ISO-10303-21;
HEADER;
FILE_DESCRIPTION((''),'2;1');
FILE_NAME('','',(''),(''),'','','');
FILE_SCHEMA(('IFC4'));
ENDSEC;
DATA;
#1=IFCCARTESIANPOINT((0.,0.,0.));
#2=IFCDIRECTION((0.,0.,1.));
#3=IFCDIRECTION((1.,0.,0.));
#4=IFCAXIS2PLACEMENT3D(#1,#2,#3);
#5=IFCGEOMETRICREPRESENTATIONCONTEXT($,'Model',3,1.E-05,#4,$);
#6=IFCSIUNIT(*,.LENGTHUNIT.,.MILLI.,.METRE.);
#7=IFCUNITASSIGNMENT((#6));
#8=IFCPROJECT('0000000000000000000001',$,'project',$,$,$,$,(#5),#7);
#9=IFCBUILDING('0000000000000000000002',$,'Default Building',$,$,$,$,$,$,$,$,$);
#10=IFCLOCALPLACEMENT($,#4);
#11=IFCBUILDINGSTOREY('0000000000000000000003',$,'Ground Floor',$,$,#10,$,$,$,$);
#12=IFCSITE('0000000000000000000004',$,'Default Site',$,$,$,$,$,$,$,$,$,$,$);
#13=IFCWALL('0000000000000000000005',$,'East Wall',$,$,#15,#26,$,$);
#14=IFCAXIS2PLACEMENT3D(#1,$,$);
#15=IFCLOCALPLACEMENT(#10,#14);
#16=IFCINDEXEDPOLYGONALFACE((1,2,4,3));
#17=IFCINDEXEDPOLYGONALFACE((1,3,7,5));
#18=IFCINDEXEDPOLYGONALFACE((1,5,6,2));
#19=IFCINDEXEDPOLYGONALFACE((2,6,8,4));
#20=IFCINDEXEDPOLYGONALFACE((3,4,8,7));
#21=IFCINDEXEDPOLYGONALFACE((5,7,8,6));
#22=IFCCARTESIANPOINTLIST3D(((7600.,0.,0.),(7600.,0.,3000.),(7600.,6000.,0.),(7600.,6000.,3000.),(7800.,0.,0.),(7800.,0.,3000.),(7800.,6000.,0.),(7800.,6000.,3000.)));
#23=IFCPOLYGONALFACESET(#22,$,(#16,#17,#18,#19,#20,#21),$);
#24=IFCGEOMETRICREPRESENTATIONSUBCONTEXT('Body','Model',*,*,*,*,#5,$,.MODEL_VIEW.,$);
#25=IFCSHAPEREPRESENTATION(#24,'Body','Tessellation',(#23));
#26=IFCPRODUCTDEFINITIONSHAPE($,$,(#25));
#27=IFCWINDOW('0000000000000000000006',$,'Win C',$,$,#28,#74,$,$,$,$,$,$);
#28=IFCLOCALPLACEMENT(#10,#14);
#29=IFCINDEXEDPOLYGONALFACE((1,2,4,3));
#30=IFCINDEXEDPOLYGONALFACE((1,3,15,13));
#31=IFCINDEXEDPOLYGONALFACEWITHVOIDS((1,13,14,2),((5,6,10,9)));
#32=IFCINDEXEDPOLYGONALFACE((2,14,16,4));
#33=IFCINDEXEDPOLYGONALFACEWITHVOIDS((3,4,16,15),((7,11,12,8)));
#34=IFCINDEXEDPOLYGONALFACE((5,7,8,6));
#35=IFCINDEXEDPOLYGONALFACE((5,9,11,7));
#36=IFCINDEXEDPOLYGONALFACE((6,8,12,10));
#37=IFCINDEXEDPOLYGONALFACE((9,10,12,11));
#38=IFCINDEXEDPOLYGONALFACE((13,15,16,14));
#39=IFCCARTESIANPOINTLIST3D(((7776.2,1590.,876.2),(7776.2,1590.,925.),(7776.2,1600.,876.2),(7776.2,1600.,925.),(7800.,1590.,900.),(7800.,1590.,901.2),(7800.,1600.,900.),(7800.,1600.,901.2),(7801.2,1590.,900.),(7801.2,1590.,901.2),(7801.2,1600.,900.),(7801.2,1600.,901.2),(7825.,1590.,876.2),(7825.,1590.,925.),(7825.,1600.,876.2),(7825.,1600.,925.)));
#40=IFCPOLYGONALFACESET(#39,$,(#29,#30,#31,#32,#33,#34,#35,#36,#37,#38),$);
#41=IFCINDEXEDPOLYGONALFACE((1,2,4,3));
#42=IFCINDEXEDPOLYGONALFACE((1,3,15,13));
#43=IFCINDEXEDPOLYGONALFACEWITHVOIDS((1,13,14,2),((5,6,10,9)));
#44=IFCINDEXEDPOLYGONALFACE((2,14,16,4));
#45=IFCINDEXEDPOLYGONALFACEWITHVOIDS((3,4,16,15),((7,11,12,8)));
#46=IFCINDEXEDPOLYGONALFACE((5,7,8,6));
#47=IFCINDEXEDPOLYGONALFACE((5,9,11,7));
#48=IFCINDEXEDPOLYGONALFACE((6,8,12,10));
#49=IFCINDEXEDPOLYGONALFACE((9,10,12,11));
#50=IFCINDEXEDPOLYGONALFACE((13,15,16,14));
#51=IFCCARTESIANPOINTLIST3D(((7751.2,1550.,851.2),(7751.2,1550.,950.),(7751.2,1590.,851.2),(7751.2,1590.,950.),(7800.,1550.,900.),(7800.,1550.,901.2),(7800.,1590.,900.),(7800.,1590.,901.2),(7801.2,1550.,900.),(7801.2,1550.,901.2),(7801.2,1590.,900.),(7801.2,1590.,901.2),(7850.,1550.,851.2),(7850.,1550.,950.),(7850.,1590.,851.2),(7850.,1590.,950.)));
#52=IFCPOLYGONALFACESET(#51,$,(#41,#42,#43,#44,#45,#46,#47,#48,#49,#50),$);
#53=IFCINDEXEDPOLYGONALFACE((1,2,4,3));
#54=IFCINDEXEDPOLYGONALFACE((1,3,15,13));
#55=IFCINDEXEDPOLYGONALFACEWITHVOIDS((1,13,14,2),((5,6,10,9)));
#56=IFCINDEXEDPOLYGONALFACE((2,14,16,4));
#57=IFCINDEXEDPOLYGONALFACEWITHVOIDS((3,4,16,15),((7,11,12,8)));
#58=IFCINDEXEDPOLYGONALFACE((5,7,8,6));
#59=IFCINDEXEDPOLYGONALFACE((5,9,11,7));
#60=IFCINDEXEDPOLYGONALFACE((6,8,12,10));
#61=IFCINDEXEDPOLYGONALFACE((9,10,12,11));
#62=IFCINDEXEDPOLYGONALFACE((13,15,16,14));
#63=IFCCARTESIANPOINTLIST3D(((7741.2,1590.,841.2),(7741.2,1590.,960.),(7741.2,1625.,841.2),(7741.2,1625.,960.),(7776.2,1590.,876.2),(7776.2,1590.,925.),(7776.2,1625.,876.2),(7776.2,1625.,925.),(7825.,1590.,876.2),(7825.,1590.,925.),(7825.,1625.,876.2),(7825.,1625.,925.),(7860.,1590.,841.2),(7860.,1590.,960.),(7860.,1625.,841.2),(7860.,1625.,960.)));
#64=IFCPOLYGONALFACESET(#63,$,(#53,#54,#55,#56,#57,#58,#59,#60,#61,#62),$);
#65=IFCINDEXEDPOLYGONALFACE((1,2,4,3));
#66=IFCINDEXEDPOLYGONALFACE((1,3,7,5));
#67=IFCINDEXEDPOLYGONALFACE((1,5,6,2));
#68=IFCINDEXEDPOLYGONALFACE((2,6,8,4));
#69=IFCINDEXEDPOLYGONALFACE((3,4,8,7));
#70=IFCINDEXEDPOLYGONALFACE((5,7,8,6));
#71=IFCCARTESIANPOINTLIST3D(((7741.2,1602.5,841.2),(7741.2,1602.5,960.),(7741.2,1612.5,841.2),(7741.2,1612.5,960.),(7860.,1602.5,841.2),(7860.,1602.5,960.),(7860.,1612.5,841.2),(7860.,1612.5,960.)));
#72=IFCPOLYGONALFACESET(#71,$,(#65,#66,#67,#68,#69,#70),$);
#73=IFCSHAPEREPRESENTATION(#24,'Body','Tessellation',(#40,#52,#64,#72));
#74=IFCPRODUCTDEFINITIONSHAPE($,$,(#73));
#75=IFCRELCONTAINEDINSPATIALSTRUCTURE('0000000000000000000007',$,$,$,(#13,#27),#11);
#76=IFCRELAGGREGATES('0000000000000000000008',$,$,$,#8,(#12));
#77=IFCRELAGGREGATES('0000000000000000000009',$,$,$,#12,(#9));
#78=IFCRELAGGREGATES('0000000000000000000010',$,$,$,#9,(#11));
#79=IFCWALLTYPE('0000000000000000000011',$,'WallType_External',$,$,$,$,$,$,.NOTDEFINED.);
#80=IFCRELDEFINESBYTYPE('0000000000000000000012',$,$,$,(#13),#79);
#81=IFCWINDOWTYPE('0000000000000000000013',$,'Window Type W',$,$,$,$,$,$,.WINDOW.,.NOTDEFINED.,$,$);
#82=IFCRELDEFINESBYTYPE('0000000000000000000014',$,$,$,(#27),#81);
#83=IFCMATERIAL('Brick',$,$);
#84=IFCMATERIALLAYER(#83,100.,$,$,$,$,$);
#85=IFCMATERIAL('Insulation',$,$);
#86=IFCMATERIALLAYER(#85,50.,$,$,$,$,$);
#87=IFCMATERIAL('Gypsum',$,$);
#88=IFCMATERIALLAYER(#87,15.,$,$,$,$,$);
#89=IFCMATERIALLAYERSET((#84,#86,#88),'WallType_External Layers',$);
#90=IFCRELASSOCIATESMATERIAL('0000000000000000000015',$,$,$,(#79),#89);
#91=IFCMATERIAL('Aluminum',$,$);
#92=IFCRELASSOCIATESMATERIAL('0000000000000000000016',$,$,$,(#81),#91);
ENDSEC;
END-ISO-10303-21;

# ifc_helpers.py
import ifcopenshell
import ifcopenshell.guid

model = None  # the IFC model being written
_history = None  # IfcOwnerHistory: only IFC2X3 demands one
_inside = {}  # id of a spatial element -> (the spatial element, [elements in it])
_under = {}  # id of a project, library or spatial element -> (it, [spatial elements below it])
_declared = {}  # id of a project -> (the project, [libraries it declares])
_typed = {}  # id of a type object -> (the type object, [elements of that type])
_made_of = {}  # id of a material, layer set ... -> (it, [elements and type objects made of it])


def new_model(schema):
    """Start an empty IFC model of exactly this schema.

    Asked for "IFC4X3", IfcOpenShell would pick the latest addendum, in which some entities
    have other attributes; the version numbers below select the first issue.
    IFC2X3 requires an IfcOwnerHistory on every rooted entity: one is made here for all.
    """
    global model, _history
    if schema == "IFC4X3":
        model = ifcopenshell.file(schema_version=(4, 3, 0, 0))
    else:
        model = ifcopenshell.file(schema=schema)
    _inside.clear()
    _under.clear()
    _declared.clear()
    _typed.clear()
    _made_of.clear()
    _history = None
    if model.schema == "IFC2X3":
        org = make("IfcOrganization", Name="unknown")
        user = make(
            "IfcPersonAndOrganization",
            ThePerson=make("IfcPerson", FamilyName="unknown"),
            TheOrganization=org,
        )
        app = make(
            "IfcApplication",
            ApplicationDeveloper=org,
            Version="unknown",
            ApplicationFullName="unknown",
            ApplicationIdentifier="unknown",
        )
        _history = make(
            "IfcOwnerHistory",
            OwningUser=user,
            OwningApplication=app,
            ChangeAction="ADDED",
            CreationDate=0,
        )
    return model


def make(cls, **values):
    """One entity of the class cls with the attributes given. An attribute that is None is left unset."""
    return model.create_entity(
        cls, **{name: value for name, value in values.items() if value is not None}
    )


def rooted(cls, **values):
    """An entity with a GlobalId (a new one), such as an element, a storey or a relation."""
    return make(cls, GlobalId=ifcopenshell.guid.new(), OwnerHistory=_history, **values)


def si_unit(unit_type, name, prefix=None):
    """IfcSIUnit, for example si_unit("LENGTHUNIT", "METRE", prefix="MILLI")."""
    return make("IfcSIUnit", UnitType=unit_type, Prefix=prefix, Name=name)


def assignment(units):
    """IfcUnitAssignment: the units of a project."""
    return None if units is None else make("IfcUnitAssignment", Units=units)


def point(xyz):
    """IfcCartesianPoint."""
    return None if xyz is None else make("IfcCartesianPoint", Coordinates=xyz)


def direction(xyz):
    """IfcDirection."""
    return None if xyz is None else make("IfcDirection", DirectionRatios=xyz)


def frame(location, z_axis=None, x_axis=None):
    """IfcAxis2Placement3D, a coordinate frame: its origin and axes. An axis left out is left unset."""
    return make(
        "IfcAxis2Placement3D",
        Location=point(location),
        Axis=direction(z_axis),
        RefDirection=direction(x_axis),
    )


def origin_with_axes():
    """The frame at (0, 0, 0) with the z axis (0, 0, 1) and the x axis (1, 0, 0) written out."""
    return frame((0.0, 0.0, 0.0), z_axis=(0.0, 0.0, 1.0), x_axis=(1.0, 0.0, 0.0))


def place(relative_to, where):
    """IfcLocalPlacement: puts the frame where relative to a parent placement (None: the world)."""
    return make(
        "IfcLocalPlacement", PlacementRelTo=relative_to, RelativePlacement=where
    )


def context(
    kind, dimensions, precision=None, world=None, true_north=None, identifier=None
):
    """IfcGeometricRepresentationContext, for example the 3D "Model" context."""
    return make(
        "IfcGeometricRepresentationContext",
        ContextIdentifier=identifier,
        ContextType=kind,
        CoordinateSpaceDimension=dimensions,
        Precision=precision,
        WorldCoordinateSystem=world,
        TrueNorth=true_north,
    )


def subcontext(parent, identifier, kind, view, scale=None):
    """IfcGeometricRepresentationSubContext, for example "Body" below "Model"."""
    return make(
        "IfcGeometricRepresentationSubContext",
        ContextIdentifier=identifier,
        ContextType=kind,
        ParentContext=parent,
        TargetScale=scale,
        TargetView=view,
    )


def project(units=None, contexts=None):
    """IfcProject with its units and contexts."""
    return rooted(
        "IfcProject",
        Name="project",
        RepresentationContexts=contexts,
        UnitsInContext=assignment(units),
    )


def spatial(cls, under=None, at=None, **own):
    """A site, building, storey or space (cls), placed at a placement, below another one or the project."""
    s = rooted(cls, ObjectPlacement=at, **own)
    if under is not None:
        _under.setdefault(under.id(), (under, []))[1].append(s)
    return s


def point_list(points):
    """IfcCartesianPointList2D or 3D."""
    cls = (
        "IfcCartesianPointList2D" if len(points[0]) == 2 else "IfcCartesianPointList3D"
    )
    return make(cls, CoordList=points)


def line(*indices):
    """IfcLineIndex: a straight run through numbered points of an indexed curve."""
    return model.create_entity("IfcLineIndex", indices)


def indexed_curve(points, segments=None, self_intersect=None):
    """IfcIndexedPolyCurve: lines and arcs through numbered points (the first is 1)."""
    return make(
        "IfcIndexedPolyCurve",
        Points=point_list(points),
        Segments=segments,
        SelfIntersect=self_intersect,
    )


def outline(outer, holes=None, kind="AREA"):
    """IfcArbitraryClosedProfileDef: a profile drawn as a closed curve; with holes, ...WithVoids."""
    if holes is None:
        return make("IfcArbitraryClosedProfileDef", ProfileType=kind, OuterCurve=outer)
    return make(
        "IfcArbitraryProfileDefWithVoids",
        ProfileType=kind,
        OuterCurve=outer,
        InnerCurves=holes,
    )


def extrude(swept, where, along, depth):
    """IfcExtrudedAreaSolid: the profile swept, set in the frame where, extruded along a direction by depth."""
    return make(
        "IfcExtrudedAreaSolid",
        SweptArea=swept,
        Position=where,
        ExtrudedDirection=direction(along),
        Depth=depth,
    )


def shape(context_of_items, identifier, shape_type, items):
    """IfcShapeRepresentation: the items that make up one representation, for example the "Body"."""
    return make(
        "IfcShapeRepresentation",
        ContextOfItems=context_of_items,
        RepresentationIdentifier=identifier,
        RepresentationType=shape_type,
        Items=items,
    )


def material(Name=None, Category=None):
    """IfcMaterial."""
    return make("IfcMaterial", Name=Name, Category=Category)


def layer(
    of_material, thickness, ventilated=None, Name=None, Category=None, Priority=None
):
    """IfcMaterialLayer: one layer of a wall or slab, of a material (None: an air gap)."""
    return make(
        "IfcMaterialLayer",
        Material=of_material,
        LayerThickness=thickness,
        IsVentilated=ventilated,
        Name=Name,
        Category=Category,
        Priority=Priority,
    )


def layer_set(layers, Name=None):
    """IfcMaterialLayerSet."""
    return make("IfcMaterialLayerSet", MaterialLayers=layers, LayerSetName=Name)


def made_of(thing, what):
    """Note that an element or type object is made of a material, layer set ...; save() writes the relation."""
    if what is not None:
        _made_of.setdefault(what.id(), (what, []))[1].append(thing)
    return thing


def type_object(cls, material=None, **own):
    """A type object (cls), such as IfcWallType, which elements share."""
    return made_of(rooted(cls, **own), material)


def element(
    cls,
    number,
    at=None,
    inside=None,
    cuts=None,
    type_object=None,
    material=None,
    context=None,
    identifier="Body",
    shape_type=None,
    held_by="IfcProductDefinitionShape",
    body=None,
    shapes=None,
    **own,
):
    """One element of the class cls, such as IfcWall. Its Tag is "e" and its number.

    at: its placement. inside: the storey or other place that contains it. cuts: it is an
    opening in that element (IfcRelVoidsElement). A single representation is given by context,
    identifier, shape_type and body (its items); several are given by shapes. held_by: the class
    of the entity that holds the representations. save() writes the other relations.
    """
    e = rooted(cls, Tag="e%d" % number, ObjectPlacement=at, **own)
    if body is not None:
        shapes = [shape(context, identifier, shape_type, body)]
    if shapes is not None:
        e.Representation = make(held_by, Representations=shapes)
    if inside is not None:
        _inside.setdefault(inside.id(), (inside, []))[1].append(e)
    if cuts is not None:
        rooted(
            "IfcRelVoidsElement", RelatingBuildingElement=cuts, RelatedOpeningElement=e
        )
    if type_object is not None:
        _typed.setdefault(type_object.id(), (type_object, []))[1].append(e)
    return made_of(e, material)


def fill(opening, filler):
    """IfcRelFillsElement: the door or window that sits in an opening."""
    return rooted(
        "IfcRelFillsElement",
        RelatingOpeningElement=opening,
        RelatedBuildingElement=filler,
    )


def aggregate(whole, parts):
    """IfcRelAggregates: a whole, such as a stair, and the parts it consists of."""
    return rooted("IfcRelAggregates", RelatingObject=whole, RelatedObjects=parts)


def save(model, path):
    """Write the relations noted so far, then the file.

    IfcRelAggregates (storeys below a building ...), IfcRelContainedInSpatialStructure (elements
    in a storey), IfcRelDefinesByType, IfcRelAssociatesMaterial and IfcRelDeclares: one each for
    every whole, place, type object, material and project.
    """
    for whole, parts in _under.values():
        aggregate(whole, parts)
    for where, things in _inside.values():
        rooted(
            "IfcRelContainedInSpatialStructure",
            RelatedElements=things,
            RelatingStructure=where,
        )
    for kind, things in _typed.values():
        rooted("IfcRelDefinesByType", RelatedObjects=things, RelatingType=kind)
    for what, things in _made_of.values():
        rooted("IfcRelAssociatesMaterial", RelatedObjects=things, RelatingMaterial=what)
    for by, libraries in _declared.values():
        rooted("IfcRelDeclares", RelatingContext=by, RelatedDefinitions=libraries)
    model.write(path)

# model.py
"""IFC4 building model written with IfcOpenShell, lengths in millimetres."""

from ifc_helpers import new_model, si_unit, frame, origin_with_axes, place, context, subcontext, project, spatial, line, indexed_curve, outline, extrude, material, layer, layer_set, type_object, element, fill, save


model = new_model("IFC4")

# Units and contexts
model_context = context("Model", 3, precision=1e-05, world=origin_with_axes())
body_context = subcontext(model_context, "Body", "Model", "MODEL_VIEW")
ifc_project = project(units=[si_unit("LENGTHUNIT", "METRE", prefix="MILLI")], contexts=[model_context])

# Site, building, storey
site = spatial("IfcSite", under=ifc_project, Name="Default Site")
building = spatial("IfcBuilding", under=site, Name="Default Building")
storey_placement = place(None, origin_with_axes())
storey = spatial("IfcBuildingStorey", under=building, at=storey_placement, Name="Ground Floor")

# Shared definitions
ifc_material_1 = material(Name="Brick")
ifc_layer_1 = layer(ifc_material_1, 100.0)
ifc_material_2 = material(Name="Insulation")
ifc_layer_2 = layer(ifc_material_2, 50.0)
ifc_material_3 = material(Name="Gypsum")
ifc_layer_3 = layer(ifc_material_3, 15.0)
ifc_layer_set_1 = layer_set([ifc_layer_1, ifc_layer_2, ifc_layer_3], Name="WallType_External Layers")
wall_type = type_object("IfcWallType", Name="WallType_External", PredefinedType="NOTDEFINED", material=ifc_layer_set_1)

# Wall, opening, window
wall_1_placement = place(storey_placement, origin_with_axes())
wall_1 = element("IfcWall", 1, at=wall_1_placement, inside=storey, type_object=wall_type, Name="East Wall", context=body_context, shape_type="SweptSolid", body=[
    extrude(outline(indexed_curve([(7800.0, 0.0), (7800.0, 6000.0), (7600.0, 6000.0), (7600.0, 0.0), (7800.0, 0.0)])), None, (0.0, 0.0, 1.0), 3000.0),
])
opening_1_placement = place(wall_1_placement, frame((0.0, 0.0, 900.0), z_axis=(0.0, 0.0, 1.0), x_axis=(1.0, 0.0, 0.0)))
opening_1 = element("IfcOpeningElement", 2, at=opening_1_placement, cuts=wall_1, context=body_context, shape_type="SweptSolid", body=[
    extrude(outline(indexed_curve([(7800.0, 1500.0), (9000.0, 1500.0), (9000.0, 1700.0), (7800.0, 1700.0), (7800.0, 1500.0)])), None, (0.0, 0.0, 1.0), 1200.0),
])
ifc_material_4 = material(Name="Aluminum")
window_type = type_object("IfcWindowType", Name="Window Type W", PartitioningType="NOTDEFINED", PredefinedType="WINDOW", material=ifc_material_4)
window_1_placement = place(storey_placement, frame((7800.0, 1500.0, 900.0), z_axis=(0.0, 0.0, 1.0), x_axis=(1.0, 0.0, 0.0)))
window_1 = element("IfcWindow", 3, at=window_1_placement, inside=storey, type_object=window_type, Name="Win C", context=body_context, shape_type="SweptSolid", body=[
    extrude(outline(indexed_curve([(0.0, 0.0), (1.2, 0.0), (1.2, 1.2), (0.0, 1.2)], segments=[line(1, 2, 3, 4, 1)]), holes=[indexed_curve([(25.0, 25.0), (-23.8, 25.0), (-23.8, -23.8), (25.0, -23.8)], segments=[line(1, 2, 3, 4, 1)])]), frame((0.0, 90.0, 0.0), z_axis=(0.0, -1.0, 0.0), x_axis=(1.0, 0.0, 0.0)), (0.0, 0.0, -1.0), 10.0),
    extrude(outline(indexed_curve([(0.0, 0.0), (1.2, 0.0), (1.2, 1.2), (0.0, 1.2)], segments=[line(1, 2, 3, 4, 1)]), holes=[indexed_curve([(50.0, 50.0), (-48.8, 50.0), (-48.8, -48.8), (50.0, -48.8)], segments=[line(1, 2, 3, 4, 1)])]), frame((0.0, 50.0, 0.0), z_axis=(0.0, -1.0, 0.0), x_axis=(1.0, 0.0, 0.0)), (0.0, 0.0, -1.0), 40.0),
    extrude(outline(indexed_curve([(0.0, 0.0), (-48.8, 0.0), (-48.8, -48.8), (0.0, -48.8)], segments=[line(1, 2, 3, 4, 1)]), holes=[indexed_curve([(35.0, 35.0), (-83.8, 35.0), (-83.8, -83.8), (35.0, -83.8)], segments=[line(1, 2, 3, 4, 1)])]), frame((25.0, 90.0, 25.0), z_axis=(0.0, -1.0, 0.0), x_axis=(1.0, 0.0, 0.0)), (0.0, 0.0, -1.0), 35.0),
    extrude(outline(indexed_curve([(35.0, 35.0), (-83.8, 35.0), (-83.8, -83.8), (35.0, -83.8)], segments=[line(1, 2, 3, 4, 1)])), frame((25.0, 102.5, 25.0), z_axis=(0.0, -1.0, 0.0), x_axis=(1.0, 0.0, 0.0)), (0.0, 0.0, -1.0), 10.0),
])
fill(opening_1, window_1)

save(model, "model.ifc")
